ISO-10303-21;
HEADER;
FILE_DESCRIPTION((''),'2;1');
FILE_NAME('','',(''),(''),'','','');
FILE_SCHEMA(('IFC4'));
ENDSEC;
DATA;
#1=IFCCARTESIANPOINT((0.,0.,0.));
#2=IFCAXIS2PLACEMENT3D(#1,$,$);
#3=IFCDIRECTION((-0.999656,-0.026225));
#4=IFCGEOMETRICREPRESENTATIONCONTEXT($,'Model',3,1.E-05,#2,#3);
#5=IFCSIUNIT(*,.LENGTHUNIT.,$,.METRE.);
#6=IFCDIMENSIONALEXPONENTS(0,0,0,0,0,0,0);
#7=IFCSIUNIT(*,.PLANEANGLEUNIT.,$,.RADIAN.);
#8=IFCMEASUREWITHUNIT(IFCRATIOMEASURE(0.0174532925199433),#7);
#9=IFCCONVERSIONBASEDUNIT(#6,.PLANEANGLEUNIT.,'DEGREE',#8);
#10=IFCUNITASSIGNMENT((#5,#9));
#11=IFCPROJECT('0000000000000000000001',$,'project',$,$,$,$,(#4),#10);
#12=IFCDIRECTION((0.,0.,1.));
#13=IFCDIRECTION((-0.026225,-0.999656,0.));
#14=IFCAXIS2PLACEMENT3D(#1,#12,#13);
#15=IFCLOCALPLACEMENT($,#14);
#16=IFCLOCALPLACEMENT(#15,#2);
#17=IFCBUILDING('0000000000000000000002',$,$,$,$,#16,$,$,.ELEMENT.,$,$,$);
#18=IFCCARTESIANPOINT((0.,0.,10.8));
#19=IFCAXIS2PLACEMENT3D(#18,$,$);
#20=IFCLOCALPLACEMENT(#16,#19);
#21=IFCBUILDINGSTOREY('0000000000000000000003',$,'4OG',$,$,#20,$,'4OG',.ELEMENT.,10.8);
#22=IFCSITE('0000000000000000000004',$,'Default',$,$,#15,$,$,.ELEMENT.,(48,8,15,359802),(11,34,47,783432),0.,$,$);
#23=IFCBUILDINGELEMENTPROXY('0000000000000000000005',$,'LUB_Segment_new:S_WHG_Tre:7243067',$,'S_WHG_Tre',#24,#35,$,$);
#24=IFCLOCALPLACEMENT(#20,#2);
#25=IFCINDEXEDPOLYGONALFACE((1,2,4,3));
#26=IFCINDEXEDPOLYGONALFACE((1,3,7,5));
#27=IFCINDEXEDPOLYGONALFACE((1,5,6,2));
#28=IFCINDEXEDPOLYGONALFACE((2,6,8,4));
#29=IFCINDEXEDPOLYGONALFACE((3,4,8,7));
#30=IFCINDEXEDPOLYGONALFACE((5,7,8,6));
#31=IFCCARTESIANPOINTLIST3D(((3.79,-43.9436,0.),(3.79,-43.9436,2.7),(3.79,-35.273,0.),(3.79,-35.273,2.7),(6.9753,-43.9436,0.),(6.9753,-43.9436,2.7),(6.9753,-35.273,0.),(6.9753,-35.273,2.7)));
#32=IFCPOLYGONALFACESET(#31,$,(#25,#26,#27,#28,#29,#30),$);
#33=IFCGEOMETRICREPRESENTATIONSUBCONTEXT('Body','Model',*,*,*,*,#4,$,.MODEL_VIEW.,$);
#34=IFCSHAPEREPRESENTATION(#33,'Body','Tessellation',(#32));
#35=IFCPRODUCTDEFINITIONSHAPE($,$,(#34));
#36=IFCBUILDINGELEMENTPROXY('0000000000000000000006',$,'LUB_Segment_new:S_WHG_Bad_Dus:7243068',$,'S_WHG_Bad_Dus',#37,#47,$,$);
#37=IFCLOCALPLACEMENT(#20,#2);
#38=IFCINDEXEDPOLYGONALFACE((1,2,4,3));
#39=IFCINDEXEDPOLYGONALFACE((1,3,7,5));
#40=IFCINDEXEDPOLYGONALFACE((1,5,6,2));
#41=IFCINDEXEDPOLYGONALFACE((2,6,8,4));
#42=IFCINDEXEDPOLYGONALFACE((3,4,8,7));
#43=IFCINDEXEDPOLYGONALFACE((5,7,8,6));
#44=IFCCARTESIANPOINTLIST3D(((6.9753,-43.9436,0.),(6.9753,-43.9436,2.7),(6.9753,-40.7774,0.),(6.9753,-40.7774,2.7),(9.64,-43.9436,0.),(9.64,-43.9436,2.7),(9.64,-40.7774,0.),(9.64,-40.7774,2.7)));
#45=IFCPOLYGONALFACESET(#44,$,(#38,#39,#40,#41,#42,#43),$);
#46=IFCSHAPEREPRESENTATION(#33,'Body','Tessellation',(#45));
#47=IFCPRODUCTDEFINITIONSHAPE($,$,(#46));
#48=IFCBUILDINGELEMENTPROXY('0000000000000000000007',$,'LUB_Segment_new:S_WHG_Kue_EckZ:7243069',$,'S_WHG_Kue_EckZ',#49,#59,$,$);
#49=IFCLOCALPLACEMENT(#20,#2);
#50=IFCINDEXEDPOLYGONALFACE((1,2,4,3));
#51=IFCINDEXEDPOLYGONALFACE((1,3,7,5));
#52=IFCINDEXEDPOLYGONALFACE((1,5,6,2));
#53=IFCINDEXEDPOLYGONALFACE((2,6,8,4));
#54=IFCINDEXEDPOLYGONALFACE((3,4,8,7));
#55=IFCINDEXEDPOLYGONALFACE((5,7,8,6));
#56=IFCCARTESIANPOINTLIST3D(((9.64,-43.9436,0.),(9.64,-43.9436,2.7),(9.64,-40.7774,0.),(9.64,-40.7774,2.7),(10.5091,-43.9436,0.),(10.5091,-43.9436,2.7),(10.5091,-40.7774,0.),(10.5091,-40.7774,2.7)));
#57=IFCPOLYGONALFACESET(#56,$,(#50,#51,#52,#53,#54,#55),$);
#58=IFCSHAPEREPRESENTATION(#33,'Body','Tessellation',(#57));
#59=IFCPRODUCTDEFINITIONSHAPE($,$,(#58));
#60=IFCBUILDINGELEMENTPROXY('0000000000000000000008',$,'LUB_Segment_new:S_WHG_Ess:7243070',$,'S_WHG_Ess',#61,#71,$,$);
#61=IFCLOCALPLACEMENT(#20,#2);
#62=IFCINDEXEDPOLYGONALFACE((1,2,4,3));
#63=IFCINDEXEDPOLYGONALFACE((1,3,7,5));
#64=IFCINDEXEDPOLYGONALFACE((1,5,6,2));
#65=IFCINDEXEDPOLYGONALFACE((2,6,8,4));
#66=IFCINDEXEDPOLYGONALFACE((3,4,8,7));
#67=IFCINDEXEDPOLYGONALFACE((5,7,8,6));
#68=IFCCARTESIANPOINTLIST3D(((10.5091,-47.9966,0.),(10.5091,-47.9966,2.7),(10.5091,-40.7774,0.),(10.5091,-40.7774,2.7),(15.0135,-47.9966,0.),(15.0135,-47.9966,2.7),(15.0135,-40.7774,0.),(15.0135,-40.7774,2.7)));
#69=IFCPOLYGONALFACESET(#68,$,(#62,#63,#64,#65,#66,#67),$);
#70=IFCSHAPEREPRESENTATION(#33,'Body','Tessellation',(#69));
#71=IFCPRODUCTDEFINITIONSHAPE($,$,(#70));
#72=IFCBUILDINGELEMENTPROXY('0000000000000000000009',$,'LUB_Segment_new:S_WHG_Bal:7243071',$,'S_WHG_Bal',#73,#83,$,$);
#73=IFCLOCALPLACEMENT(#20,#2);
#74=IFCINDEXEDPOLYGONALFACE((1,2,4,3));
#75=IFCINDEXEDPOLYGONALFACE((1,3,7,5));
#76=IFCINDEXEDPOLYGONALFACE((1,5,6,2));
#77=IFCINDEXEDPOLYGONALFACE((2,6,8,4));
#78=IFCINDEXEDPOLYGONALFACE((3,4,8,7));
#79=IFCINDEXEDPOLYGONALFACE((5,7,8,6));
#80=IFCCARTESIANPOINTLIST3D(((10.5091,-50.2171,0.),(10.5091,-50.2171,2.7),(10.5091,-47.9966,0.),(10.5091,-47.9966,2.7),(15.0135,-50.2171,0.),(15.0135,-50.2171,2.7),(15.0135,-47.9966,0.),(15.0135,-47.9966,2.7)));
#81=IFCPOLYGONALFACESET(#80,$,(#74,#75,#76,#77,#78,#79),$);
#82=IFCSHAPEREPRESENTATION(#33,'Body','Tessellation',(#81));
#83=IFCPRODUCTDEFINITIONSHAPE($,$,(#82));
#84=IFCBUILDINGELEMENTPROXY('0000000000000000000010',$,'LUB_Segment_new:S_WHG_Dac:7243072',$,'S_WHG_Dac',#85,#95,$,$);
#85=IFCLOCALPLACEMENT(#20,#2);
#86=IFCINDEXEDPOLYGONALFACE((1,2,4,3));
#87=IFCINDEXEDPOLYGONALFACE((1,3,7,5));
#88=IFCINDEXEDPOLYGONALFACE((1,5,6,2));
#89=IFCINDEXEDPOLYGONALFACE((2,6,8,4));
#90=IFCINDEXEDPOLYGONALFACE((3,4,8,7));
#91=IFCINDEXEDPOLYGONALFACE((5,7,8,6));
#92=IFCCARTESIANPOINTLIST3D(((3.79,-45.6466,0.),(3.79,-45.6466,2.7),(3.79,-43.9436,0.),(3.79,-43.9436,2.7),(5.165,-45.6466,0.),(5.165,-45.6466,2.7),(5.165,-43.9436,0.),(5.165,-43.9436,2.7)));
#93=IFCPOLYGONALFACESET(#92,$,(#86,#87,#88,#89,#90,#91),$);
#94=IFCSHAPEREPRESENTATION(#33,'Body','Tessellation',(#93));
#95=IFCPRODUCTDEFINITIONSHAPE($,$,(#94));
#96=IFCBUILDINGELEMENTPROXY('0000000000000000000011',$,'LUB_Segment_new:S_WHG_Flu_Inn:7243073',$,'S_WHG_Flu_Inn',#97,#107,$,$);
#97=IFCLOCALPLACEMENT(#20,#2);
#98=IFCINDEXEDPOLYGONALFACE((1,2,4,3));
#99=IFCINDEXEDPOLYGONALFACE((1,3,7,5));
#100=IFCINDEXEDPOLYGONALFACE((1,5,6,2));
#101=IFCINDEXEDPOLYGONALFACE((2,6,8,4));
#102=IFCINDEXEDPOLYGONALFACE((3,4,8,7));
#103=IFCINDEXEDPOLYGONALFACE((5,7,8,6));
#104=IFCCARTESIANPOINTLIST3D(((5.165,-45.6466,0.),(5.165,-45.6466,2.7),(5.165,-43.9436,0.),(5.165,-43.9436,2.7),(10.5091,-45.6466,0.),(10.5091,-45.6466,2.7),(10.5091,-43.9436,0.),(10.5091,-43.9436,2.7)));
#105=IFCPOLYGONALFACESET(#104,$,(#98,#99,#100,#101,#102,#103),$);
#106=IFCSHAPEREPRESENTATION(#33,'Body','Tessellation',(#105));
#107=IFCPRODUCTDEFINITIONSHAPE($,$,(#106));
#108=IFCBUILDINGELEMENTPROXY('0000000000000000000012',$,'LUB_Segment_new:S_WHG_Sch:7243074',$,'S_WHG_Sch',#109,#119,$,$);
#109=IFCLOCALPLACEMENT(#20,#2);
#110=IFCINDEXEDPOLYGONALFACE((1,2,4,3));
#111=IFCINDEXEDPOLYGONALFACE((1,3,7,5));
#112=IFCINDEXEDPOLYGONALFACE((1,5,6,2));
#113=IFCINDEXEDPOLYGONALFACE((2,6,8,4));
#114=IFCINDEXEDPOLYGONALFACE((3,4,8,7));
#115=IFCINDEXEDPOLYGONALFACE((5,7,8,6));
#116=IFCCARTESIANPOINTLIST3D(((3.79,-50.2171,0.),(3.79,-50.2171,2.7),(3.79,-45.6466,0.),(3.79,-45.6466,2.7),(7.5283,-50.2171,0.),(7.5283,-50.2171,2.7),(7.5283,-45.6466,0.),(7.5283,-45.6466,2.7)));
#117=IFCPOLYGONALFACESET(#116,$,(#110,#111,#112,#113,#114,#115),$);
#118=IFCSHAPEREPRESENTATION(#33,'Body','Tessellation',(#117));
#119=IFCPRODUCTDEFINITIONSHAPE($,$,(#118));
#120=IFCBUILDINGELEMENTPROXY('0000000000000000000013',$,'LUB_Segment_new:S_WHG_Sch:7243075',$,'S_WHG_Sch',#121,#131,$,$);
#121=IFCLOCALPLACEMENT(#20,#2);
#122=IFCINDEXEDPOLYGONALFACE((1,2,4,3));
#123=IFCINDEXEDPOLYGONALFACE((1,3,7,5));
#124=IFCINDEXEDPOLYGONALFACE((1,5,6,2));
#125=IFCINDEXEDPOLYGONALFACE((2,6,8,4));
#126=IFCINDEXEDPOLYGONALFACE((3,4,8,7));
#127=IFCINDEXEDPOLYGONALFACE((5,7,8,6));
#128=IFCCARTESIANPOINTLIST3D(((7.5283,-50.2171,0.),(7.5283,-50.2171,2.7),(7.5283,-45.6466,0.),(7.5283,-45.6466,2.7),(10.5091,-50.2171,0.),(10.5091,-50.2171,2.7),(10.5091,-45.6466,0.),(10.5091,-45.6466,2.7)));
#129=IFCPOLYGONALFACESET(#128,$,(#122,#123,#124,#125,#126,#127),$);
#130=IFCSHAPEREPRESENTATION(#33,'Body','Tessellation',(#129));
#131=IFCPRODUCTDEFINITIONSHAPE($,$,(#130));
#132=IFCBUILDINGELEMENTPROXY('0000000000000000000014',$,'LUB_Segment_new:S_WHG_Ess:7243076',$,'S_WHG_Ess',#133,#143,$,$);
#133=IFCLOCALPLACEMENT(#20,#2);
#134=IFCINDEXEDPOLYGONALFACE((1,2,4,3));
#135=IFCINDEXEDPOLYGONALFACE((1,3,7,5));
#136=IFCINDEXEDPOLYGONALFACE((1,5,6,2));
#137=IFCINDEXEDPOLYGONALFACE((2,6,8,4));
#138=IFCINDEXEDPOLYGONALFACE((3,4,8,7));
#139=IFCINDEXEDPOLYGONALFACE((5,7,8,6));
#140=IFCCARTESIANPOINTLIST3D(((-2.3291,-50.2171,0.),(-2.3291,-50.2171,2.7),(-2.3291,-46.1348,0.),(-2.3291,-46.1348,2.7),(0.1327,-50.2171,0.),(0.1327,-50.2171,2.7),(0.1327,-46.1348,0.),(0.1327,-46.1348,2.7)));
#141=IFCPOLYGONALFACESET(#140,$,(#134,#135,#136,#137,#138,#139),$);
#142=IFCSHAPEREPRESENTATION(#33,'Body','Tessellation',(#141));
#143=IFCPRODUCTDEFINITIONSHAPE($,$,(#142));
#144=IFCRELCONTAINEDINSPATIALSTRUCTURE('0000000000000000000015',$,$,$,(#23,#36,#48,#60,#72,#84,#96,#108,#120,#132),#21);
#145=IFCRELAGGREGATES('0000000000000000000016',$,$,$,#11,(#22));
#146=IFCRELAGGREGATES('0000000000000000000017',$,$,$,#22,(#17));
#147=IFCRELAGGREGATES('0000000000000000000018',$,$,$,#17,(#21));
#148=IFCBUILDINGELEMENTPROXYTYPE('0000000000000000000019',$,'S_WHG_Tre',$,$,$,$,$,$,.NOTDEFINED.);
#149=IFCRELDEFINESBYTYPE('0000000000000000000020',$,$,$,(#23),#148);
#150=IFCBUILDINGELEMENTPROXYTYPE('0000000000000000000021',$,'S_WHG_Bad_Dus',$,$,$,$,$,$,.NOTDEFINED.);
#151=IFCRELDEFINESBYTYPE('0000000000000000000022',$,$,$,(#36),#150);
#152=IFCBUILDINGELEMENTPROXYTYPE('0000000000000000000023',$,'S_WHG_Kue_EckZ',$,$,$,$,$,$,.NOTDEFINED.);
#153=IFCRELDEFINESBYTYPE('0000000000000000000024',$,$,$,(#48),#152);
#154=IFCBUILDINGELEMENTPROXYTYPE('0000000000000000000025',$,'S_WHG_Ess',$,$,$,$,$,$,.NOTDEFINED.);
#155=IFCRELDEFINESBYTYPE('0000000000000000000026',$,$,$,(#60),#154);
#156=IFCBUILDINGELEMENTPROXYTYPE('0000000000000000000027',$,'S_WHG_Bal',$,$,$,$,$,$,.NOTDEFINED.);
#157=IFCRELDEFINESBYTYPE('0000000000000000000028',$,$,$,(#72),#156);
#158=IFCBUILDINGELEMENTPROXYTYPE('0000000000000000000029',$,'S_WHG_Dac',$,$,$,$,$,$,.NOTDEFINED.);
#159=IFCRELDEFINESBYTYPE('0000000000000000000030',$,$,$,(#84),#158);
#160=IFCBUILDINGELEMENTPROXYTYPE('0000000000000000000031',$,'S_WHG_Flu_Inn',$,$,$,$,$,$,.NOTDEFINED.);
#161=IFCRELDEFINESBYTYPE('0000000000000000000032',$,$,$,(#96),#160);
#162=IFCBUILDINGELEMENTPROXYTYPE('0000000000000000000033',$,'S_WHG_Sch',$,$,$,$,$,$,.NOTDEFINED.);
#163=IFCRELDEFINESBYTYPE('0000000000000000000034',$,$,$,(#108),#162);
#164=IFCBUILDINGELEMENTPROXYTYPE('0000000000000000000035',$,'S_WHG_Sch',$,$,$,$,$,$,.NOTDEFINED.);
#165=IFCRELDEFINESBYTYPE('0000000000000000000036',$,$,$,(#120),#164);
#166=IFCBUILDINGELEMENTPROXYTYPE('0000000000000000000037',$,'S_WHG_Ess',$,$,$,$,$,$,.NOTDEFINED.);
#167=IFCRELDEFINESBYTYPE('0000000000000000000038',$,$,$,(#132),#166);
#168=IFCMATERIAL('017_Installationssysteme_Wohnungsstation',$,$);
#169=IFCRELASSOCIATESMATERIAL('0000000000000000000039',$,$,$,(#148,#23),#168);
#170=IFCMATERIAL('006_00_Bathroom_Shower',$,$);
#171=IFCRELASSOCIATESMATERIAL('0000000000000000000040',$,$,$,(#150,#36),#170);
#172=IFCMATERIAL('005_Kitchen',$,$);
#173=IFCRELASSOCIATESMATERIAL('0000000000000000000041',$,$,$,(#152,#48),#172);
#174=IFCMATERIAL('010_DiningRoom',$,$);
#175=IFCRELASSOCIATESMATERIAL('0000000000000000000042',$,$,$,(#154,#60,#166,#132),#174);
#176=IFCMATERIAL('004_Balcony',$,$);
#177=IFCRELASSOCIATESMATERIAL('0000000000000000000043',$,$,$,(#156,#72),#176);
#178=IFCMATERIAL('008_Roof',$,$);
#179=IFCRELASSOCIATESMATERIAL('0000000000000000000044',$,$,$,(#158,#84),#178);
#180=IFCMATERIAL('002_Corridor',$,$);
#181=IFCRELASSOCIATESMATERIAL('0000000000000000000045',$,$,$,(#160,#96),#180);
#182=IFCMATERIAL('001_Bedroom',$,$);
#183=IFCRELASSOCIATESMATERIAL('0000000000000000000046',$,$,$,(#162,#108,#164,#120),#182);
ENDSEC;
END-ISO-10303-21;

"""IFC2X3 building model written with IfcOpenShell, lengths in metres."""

from ifc_helpers import new_model, entity, si_unit, converted_unit, direction, frame, frame_2d, origin, origin_2d_with_axis, place, context, subcontext, project, spatial, rectangle, extrude, source, transform, mapped, material, type_object, type_shapes, element, save


model = new_model("IFC2X3")

# Units and contexts
model_context = context("Model", 3, precision=1e-05, world=origin(), true_north=direction((-0.999656, -0.026225)))
body_context = subcontext(model_context, "Body", "Model", "MODEL_VIEW")
ifc_project = project(units=[si_unit("LENGTHUNIT", "METRE"), converted_unit("PLANEANGLEUNIT", "DEGREE", entity("IfcRatioMeasure", 0.0174532925199433), si_unit("PLANEANGLEUNIT", "RADIAN"), dimensions=[0, 0, 0, 0, 0, 0, 0])], contexts=[model_context])

# Site, building, storey
site_placement = place(None, frame((0.0, 0.0, 0.0), z_axis=(0.0, 0.0, 1.0), x_axis=(-0.026225, -0.999656, 0.0)))
site = spatial("IfcSite", under=ifc_project, at=site_placement, Name="Default", CompositionType="ELEMENT", RefLatitude=(48, 8, 15, 359802), RefLongitude=(11, 34, 47, 783432), RefElevation=0.0)
building_placement = place(site_placement, origin())
building = spatial("IfcBuilding", under=site, at=building_placement, CompositionType="ELEMENT")
storey_placement = place(building_placement, frame((0.0, 0.0, 10.8)))
storey = spatial("IfcBuildingStorey", under=building, at=storey_placement, Name="4OG", LongName="4OG", CompositionType="ELEMENT", Elevation=10.8)

# Building element proxies
ifc_material_1 = material(Name="001_Bedroom")
ifc_material_2 = material(Name="010_DiningRoom")
ifc_material_3 = material(Name="004_Balcony")
ifc_material_4 = material(Name="005_Kitchen")
ifc_material_5 = material(Name="002_Corridor")
ifc_material_6 = material(Name="008_Roof")
ifc_material_7 = material(Name="006_00_Bathroom_Shower")
ifc_material_8 = material(Name="017_Installationssysteme_Wohnungsstation")
building_element_proxy_type_1 = type_object("IfcBuildingElementProxyType", Name="S_WHG_Tre", PredefinedType="NOTDEFINED", material=ifc_material_8)
shared_shape_1 = source(origin(), body_context, "Body", "SweptSolid", [
    extrude(rectangle(XDim=3.1853, YDim=8.6706, at=frame_2d((0.0, 0.0), x_axis=(1.0, 0.0))), frame((0.0, 0.0, 0.0), z_axis=(0.0, 0.0, 1.0), x_axis=(-1.0, 0.0, 0.0)), (0.0, 0.0, 1.0), 2.7),
])
type_shapes(building_element_proxy_type_1, [shared_shape_1])
proxy_1_placement = place(storey_placement, frame((5.3827, -39.6083, 0.0)))
element("IfcBuildingElementProxy", 1, at=proxy_1_placement, inside=storey, type_object=building_element_proxy_type_1, material=ifc_material_8, Name="LUB_Segment_new:S_WHG_Tre:7243067", ObjectType="S_WHG_Tre", context=body_context, shape_type="MappedRepresentation", body=[
    mapped(shared_shape_1, transform((0.0, 0.0, 0.0), scale=1.0)),
])
building_element_proxy_type_2 = type_object("IfcBuildingElementProxyType", Name="S_WHG_Bad_Dus", PredefinedType="NOTDEFINED", material=ifc_material_7)
shared_shape_2 = source(origin(), body_context, "Body", "SweptSolid", [
    extrude(rectangle(XDim=3.1662, YDim=2.6647, at=origin_2d_with_axis()), frame((0.0, 0.0, 0.0), z_axis=(0.0, 0.0, 1.0), x_axis=(0.0, 1.0, 0.0)), (0.0, 0.0, 1.0), 2.7),
])
type_shapes(building_element_proxy_type_2, [shared_shape_2])
proxy_2_placement = place(storey_placement, frame((8.3077, -42.3605, 0.0)))
element("IfcBuildingElementProxy", 2, at=proxy_2_placement, inside=storey, type_object=building_element_proxy_type_2, material=ifc_material_7, Name="LUB_Segment_new:S_WHG_Bad_Dus:7243068", ObjectType="S_WHG_Bad_Dus", context=body_context, shape_type="MappedRepresentation", body=[
    mapped(shared_shape_2, transform((0.0, 0.0, 0.0), scale=1.0)),
])
building_element_proxy_type_3 = type_object("IfcBuildingElementProxyType", Name="S_WHG_Kue_EckZ", PredefinedType="NOTDEFINED", material=ifc_material_4)
shared_shape_3 = source(origin(), body_context, "Body", "SweptSolid", [
    extrude(rectangle(XDim=3.1662, YDim=0.8691, at=origin_2d_with_axis()), frame((0.0, 0.0, 0.0), z_axis=(0.0, 0.0, 1.0), x_axis=(0.0, 1.0, 0.0)), (0.0, 0.0, 1.0), 2.7),
])
type_shapes(building_element_proxy_type_3, [shared_shape_3])
proxy_3_placement = place(storey_placement, frame((10.0746, -42.3605, 0.0)))
element("IfcBuildingElementProxy", 3, at=proxy_3_placement, inside=storey, type_object=building_element_proxy_type_3, material=ifc_material_4, Name="LUB_Segment_new:S_WHG_Kue_EckZ:7243069", ObjectType="S_WHG_Kue_EckZ", context=body_context, shape_type="MappedRepresentation", body=[
    mapped(shared_shape_3, transform((0.0, 0.0, 0.0), scale=1.0)),
])
building_element_proxy_type_4 = type_object("IfcBuildingElementProxyType", Name="S_WHG_Ess", PredefinedType="NOTDEFINED", material=ifc_material_2)
shared_shape_4 = source(origin(), body_context, "Body", "SweptSolid", [
    extrude(rectangle(XDim=4.5044, YDim=7.2191, at=origin_2d_with_axis()), frame((0.0, 0.0, 0.0), z_axis=(0.0, 0.0, 1.0), x_axis=(-1.0, 0.0, 0.0)), (0.0, 0.0, 1.0), 2.7),
])
type_shapes(building_element_proxy_type_4, [shared_shape_4])
proxy_4_placement = place(storey_placement, frame((12.7613, -44.387, 0.0)))
element("IfcBuildingElementProxy", 4, at=proxy_4_placement, inside=storey, type_object=building_element_proxy_type_4, material=ifc_material_2, Name="LUB_Segment_new:S_WHG_Ess:7243070", ObjectType="S_WHG_Ess", context=body_context, shape_type="MappedRepresentation", body=[
    mapped(shared_shape_4, transform((0.0, 0.0, 0.0), scale=1.0)),
])
building_element_proxy_type_5 = type_object("IfcBuildingElementProxyType", Name="S_WHG_Bal", PredefinedType="NOTDEFINED", material=ifc_material_3)
shared_shape_5 = source(origin(), body_context, "Body", "SweptSolid", [
    extrude(rectangle(XDim=2.2206, YDim=4.5044, at=origin_2d_with_axis()), frame((0.0, 0.0, 0.0), z_axis=(0.0, 0.0, 1.0), x_axis=(0.0, 1.0, 0.0)), (0.0, 0.0, 1.0), 2.7),
])
type_shapes(building_element_proxy_type_5, [shared_shape_5])
proxy_5_placement = place(storey_placement, frame((12.7613, -49.1068, 0.0)))
element("IfcBuildingElementProxy", 5, at=proxy_5_placement, inside=storey, type_object=building_element_proxy_type_5, material=ifc_material_3, Name="LUB_Segment_new:S_WHG_Bal:7243071", ObjectType="S_WHG_Bal", context=body_context, shape_type="MappedRepresentation", body=[
    mapped(shared_shape_5, transform((0.0, 0.0, 0.0), scale=1.0)),
])
building_element_proxy_type_6 = type_object("IfcBuildingElementProxyType", Name="S_WHG_Dac", PredefinedType="NOTDEFINED", material=ifc_material_6)
shared_shape_6 = source(origin(), body_context, "Body", "SweptSolid", [
    extrude(rectangle(XDim=1.7029, YDim=1.375, at=origin_2d_with_axis()), frame((0.0, 0.0, 0.0), z_axis=(0.0, 0.0, 1.0), x_axis=(0.0, 1.0, 0.0)), (0.0, 0.0, 1.0), 2.7),
])
type_shapes(building_element_proxy_type_6, [shared_shape_6])
proxy_6_placement = place(storey_placement, frame((4.4775, -44.7951, 0.0)))
element("IfcBuildingElementProxy", 6, at=proxy_6_placement, inside=storey, type_object=building_element_proxy_type_6, material=ifc_material_6, Name="LUB_Segment_new:S_WHG_Dac:7243072", ObjectType="S_WHG_Dac", context=body_context, shape_type="MappedRepresentation", body=[
    mapped(shared_shape_6, transform((0.0, 0.0, 0.0), scale=1.0)),
])
building_element_proxy_type_7 = type_object("IfcBuildingElementProxyType", Name="S_WHG_Flu_Inn", PredefinedType="NOTDEFINED", material=ifc_material_5)
shared_shape_7 = source(origin(), body_context, "Body", "SweptSolid", [
    extrude(rectangle(XDim=1.7029, YDim=5.3441, at=origin_2d_with_axis()), frame((0.0, 0.0, 0.0), z_axis=(0.0, 0.0, 1.0), x_axis=(0.0, 1.0, 0.0)), (0.0, 0.0, 1.0), 2.7),
])
type_shapes(building_element_proxy_type_7, [shared_shape_7])
proxy_7_placement = place(storey_placement, frame((7.8371, -44.7951, 0.0)))
element("IfcBuildingElementProxy", 7, at=proxy_7_placement, inside=storey, type_object=building_element_proxy_type_7, material=ifc_material_5, Name="LUB_Segment_new:S_WHG_Flu_Inn:7243073", ObjectType="S_WHG_Flu_Inn", context=body_context, shape_type="MappedRepresentation", body=[
    mapped(shared_shape_7, transform((0.0, 0.0, 0.0), scale=1.0)),
])
building_element_proxy_type_8 = type_object("IfcBuildingElementProxyType", Name="S_WHG_Sch", PredefinedType="NOTDEFINED", material=ifc_material_1)
shared_shape_8 = source(origin(), body_context, "Body", "SweptSolid", [
    extrude(rectangle(XDim=3.7382, YDim=4.5706, at=origin_2d_with_axis()), frame((0.0, 0.0, 0.0), z_axis=(0.0, 0.0, 1.0), x_axis=(-1.0, 0.0, 0.0)), (0.0, 0.0, 1.0), 2.7),
])
type_shapes(building_element_proxy_type_8, [shared_shape_8])
proxy_8_placement = place(storey_placement, frame((5.6591, -47.9318, 0.0)))
element("IfcBuildingElementProxy", 8, at=proxy_8_placement, inside=storey, type_object=building_element_proxy_type_8, material=ifc_material_1, Name="LUB_Segment_new:S_WHG_Sch:7243074", ObjectType="S_WHG_Sch", context=body_context, shape_type="MappedRepresentation", body=[
    mapped(shared_shape_8, transform((0.0, 0.0, 0.0), scale=1.0)),
])
building_element_proxy_type_9 = type_object("IfcBuildingElementProxyType", Name="S_WHG_Sch", PredefinedType="NOTDEFINED", material=ifc_material_1)
shared_shape_9 = source(origin(), body_context, "Body", "SweptSolid", [
    extrude(rectangle(XDim=2.9809, YDim=4.5706, at=origin_2d_with_axis()), frame((0.0, 0.0, 0.0), z_axis=(0.0, 0.0, 1.0), x_axis=(-1.0, 0.0, 0.0)), (0.0, 0.0, 1.0), 2.7),
])
type_shapes(building_element_proxy_type_9, [shared_shape_9])
proxy_9_placement = place(storey_placement, frame((9.0187, -47.9318, 0.0)))
element("IfcBuildingElementProxy", 9, at=proxy_9_placement, inside=storey, type_object=building_element_proxy_type_9, material=ifc_material_1, Name="LUB_Segment_new:S_WHG_Sch:7243075", ObjectType="S_WHG_Sch", context=body_context, shape_type="MappedRepresentation", body=[
    mapped(shared_shape_9, transform((0.0, 0.0, 0.0), scale=1.0)),
])
building_element_proxy_type_10 = type_object("IfcBuildingElementProxyType", Name="S_WHG_Ess", PredefinedType="NOTDEFINED", material=ifc_material_2)
shared_shape_10 = source(origin(), body_context, "Body", "SweptSolid", [
    extrude(rectangle(XDim=4.0824, YDim=2.4618, at=origin_2d_with_axis()), frame((0.0, 0.0, 0.0), z_axis=(0.0, 0.0, 1.0), x_axis=(0.0, 1.0, 0.0)), (0.0, 0.0, 1.0), 2.7),
])
type_shapes(building_element_proxy_type_10, [shared_shape_10])
proxy_10_placement = place(storey_placement, frame((-1.0982, -48.176, 0.0)))
element("IfcBuildingElementProxy", 10, at=proxy_10_placement, inside=storey, type_object=building_element_proxy_type_10, material=ifc_material_2, Name="LUB_Segment_new:S_WHG_Ess:7243076", ObjectType="S_WHG_Ess", context=body_context, shape_type="MappedRepresentation", body=[
    mapped(shared_shape_10, transform((0.0, 0.0, 0.0), scale=1.0)),
])

save(model, "model.ifc")
